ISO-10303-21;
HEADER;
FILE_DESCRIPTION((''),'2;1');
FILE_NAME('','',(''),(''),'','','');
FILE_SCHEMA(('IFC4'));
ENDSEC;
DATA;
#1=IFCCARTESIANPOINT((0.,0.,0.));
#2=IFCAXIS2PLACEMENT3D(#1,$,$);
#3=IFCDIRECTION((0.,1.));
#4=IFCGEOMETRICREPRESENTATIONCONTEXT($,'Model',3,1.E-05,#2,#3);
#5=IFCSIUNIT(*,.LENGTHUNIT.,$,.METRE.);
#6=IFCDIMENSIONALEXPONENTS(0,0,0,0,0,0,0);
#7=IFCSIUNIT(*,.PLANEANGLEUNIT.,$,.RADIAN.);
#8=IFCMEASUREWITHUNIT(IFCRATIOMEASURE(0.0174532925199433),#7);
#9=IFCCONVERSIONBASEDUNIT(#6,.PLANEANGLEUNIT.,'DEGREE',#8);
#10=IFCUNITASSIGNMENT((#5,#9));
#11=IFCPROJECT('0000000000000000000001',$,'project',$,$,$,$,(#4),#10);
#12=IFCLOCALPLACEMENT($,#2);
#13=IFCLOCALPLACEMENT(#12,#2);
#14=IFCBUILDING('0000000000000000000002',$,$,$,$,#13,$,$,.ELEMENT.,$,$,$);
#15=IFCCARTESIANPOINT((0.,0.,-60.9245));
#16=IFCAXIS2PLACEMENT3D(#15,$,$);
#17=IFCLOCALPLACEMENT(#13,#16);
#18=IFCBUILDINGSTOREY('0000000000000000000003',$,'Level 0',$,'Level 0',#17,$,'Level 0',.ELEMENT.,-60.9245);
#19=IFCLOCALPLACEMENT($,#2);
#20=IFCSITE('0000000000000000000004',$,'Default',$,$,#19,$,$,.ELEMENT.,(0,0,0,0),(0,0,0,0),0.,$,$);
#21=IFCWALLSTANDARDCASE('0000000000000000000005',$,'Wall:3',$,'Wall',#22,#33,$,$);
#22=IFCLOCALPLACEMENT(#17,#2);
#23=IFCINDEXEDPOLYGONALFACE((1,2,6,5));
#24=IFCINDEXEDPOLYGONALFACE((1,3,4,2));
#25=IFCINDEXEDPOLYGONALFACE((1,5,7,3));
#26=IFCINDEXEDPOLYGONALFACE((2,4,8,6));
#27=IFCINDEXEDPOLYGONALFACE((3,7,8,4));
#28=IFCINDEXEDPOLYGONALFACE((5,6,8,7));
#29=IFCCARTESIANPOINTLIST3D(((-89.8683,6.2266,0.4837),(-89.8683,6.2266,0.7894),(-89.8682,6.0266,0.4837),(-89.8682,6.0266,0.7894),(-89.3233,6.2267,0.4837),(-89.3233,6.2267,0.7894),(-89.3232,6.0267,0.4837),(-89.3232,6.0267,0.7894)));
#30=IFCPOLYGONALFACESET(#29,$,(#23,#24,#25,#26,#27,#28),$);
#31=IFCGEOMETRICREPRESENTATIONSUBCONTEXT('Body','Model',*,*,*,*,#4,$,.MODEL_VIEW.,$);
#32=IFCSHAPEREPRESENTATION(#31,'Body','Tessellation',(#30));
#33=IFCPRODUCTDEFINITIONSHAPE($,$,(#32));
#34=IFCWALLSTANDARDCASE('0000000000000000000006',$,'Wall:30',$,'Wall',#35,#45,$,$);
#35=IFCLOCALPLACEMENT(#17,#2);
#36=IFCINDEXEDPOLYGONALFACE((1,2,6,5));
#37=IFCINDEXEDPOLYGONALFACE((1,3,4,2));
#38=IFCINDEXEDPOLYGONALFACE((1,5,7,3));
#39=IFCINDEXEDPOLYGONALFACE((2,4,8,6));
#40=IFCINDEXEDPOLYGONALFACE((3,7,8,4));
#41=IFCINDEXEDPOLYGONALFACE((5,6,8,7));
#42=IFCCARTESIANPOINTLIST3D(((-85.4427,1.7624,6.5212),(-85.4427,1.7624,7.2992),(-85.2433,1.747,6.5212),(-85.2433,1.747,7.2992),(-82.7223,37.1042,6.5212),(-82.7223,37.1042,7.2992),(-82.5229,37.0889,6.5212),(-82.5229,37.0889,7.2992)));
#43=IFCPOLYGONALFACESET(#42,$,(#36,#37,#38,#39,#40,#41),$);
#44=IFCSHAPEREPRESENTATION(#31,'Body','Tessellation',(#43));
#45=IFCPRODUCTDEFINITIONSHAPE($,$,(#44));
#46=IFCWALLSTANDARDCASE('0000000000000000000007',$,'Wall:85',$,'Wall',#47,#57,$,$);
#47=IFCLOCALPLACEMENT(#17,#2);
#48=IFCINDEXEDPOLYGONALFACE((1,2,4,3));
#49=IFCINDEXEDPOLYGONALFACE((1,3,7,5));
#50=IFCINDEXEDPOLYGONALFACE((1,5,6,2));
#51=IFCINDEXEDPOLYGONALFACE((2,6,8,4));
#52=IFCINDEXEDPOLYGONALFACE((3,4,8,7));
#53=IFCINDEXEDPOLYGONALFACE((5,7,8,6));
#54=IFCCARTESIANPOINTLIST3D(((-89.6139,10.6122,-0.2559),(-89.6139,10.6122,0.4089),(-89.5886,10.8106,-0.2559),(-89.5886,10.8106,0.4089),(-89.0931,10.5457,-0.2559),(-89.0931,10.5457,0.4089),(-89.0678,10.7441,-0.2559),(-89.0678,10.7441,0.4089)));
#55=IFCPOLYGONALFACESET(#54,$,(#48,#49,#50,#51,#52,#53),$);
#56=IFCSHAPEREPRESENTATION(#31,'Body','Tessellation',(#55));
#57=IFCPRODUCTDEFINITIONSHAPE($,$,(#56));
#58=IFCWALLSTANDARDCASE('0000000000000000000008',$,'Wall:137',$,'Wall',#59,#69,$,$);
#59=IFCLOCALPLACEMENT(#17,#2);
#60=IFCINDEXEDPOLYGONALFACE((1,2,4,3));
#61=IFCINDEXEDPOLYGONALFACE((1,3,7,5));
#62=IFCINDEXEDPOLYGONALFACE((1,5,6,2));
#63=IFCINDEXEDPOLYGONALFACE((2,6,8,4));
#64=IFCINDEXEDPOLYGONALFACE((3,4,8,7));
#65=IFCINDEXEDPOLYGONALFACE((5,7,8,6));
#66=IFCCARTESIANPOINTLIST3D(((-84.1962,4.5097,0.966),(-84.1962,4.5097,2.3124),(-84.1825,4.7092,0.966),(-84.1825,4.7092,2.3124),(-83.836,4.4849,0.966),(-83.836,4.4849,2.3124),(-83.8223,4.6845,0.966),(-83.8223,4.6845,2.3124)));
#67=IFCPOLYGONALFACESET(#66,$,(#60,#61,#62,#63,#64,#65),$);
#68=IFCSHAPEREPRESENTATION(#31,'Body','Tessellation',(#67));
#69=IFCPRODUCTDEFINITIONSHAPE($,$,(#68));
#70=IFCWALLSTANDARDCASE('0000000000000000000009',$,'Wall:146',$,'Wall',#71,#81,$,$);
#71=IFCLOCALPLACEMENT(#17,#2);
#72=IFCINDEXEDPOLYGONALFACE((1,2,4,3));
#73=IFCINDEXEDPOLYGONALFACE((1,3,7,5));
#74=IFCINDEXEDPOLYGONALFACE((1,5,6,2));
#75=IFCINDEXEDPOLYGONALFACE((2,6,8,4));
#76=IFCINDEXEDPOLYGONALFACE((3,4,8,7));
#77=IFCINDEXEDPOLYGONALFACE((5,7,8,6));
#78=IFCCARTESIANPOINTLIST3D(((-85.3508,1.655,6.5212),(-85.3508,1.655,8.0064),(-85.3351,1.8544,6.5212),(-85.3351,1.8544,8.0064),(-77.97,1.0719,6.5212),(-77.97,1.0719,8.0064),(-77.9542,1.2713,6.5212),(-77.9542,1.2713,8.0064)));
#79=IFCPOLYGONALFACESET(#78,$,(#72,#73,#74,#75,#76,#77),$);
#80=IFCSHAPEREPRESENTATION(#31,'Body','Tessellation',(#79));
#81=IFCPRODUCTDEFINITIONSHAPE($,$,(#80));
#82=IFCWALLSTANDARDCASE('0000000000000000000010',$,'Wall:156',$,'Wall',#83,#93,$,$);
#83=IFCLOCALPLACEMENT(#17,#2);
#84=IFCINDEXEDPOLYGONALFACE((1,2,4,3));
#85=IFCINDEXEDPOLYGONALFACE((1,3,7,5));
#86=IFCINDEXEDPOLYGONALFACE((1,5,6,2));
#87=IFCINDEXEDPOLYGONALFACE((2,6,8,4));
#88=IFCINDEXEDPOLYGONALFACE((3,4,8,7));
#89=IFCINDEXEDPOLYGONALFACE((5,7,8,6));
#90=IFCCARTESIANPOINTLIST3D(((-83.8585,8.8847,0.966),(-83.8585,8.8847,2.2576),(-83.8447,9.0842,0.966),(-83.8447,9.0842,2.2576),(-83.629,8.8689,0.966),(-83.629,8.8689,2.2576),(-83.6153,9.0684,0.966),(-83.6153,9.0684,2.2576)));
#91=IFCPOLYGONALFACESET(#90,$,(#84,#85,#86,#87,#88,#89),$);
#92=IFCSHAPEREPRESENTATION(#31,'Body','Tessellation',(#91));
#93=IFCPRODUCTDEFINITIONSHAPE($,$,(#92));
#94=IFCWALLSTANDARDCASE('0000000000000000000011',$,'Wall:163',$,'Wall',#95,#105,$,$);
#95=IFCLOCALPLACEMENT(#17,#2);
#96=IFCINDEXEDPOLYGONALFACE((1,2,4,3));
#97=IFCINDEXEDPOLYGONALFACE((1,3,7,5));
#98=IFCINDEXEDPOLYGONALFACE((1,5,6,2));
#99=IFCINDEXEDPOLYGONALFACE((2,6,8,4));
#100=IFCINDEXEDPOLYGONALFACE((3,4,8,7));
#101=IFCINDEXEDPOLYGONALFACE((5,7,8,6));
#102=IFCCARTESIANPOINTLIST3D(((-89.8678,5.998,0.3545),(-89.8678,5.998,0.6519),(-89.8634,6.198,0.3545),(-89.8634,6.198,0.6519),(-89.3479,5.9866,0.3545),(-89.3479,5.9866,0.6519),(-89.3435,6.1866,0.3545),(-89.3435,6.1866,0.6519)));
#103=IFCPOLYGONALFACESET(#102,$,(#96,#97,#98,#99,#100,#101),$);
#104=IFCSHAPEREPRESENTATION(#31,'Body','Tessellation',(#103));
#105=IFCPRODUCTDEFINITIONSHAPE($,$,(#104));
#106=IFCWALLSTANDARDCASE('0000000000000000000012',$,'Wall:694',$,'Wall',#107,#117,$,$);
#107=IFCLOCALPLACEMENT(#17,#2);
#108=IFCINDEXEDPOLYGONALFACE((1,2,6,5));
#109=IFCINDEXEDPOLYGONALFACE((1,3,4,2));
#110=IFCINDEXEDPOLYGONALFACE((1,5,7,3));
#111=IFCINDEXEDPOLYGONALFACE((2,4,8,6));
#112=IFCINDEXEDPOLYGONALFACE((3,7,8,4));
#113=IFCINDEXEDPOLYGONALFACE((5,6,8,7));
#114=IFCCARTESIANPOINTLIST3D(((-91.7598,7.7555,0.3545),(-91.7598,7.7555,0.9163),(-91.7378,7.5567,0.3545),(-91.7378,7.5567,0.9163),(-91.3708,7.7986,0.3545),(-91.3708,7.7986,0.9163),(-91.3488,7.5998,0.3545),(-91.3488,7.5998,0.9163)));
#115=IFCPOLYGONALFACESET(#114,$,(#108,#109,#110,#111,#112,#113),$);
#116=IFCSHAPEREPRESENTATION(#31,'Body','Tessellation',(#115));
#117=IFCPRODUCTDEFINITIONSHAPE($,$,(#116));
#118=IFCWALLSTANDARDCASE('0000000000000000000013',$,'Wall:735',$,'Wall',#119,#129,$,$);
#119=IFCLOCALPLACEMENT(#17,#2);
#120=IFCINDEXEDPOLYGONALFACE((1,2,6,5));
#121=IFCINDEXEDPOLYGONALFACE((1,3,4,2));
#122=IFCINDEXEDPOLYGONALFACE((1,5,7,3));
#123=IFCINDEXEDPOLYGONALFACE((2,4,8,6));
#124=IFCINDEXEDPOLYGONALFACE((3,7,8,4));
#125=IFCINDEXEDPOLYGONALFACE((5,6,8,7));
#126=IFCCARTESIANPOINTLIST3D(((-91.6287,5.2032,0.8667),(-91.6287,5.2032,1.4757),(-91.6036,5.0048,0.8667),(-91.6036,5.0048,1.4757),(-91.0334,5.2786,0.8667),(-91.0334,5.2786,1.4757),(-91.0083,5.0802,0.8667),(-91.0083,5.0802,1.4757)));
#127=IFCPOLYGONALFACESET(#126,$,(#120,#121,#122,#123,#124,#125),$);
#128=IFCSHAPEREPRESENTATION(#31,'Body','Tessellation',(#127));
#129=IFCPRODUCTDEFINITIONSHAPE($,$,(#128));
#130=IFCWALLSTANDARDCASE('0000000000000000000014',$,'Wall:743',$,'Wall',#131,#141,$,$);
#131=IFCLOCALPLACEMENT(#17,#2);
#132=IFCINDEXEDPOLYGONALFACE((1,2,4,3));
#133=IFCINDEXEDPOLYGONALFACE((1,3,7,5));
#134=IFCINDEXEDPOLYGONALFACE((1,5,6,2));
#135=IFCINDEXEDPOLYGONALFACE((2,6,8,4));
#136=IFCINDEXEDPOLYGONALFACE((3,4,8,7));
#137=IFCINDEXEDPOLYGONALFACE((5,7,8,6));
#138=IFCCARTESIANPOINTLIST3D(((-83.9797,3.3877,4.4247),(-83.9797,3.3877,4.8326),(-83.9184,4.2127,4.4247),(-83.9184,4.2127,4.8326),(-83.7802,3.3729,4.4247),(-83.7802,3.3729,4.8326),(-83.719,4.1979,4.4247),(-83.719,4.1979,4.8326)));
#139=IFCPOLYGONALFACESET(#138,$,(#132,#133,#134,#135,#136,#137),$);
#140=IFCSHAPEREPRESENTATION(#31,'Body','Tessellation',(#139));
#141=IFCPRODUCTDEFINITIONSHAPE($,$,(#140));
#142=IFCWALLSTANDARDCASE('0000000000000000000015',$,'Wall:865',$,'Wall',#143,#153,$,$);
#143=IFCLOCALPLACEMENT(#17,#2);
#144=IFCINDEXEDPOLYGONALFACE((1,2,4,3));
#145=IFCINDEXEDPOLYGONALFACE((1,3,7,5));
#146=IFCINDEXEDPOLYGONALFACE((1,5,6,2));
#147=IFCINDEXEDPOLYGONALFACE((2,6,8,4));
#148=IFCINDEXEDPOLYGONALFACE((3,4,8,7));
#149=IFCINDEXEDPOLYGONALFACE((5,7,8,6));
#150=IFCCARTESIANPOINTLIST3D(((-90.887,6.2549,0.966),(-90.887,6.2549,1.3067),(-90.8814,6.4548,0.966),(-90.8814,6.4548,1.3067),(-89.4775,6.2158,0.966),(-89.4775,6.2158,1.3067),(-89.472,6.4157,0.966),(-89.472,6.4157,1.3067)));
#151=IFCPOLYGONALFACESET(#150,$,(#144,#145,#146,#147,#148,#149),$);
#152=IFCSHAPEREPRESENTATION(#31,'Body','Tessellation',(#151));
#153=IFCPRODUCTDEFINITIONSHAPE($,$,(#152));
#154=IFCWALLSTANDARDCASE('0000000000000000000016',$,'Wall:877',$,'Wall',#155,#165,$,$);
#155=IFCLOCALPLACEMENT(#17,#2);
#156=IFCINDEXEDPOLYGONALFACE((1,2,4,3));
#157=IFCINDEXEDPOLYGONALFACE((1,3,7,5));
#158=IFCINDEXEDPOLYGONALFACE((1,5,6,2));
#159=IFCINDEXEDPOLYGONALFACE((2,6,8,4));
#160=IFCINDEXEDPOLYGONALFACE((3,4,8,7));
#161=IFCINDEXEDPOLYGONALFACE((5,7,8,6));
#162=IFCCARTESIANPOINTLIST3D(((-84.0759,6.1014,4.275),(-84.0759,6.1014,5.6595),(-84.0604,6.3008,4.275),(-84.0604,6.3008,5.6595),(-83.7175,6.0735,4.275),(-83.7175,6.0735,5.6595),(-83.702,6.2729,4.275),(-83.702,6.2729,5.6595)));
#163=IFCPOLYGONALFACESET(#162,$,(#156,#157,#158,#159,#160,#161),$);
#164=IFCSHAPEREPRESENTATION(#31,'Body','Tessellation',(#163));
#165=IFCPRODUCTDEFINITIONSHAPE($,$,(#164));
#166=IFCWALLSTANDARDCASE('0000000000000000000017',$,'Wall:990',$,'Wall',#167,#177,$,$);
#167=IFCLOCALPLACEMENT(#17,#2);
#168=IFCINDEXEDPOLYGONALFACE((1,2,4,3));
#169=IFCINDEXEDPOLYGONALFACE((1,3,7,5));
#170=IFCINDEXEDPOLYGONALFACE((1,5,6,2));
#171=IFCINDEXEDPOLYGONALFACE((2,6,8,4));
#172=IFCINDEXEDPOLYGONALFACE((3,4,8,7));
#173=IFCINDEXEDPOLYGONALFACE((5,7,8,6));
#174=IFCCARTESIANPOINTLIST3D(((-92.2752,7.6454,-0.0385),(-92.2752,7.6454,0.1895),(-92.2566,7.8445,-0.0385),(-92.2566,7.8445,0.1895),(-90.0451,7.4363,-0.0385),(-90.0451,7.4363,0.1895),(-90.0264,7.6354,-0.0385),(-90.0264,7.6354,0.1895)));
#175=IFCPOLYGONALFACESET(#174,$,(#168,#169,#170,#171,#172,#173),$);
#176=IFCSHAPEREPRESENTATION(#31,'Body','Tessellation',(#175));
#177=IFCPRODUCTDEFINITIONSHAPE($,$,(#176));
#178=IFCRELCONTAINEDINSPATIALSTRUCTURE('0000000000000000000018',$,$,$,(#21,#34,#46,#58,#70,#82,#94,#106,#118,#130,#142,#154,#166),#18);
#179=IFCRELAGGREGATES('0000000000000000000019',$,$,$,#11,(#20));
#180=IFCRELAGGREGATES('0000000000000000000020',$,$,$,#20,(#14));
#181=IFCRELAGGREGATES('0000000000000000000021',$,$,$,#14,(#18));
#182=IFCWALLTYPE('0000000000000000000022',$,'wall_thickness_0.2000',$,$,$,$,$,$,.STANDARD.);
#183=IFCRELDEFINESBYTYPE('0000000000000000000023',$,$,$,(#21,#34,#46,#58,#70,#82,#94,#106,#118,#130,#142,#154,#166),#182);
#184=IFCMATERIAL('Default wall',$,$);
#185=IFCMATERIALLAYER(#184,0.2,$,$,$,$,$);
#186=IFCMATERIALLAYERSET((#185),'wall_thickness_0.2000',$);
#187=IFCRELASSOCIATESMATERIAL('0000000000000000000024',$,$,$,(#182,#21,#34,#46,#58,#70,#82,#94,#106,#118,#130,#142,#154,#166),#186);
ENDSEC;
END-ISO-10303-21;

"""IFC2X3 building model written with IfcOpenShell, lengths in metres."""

from ifc_helpers import new_model, entity, si_unit, converted_unit, direction, frame, origin, place, context, subcontext, project, spatial, polyline, outline, extrude, material, layer, layer_set, layer_usage, type_object, element, save


model = new_model("IFC2X3")

# Units and contexts
model_context = context("Model", 3, precision=1e-05, world=origin(), true_north=direction((0.0, 1.0)))
body_context = subcontext(model_context, "Body", "Model", "MODEL_VIEW")
ifc_project = project(units=[si_unit("LENGTHUNIT", "METRE"), converted_unit("PLANEANGLEUNIT", "DEGREE", entity("IfcRatioMeasure", 0.0174532925199433), si_unit("PLANEANGLEUNIT", "RADIAN"), dimensions=[0, 0, 0, 0, 0, 0, 0])], contexts=[model_context])

# Site, building, storey
site_placement = place(None, origin())
site = spatial("IfcSite", under=ifc_project, at=site_placement, Name="Default", CompositionType="ELEMENT", RefLatitude=(0, 0, 0, 0), RefLongitude=(0, 0, 0, 0), RefElevation=0.0)
placement_1 = place(None, origin())
building_placement = place(placement_1, origin())
building = spatial("IfcBuilding", under=site, at=building_placement, CompositionType="ELEMENT")
storey_placement = place(building_placement, frame((0.0, 0.0, -60.9245)))
storey = spatial("IfcBuildingStorey", under=building, at=storey_placement, Name="Level 0", ObjectType="Level 0", LongName="Level 0", CompositionType="ELEMENT", Elevation=-60.9245)

# Walls
ifc_material = material(Name="Default wall")
ifc_layer = layer(ifc_material, 0.2)
ifc_layer_set = layer_set([ifc_layer], Name="wall_thickness_0.2000")
ifc_layer_usage = layer_usage(ifc_layer_set, "AXIS2", "POSITIVE", -0.1)
wall_type = type_object("IfcWallType", Name="wall_thickness_0.2000", PredefinedType="STANDARD", material=ifc_layer_set)
placement_2 = place(building_placement, frame((0.0, 0.0, -60.4408)))
wall_1_placement = place(placement_2, frame((-89.8683, 6.1266, 0.0), z_axis=(0.0, 0.0, 1.0), x_axis=(1.0, 0.000196, 0.0)))
element("IfcWallStandardCase", 1, at=wall_1_placement, inside=storey, type_object=wall_type, material=ifc_layer_usage, Name="Wall:3", ObjectType="Wall", context=body_context, shape_type="SweptSolid", body=[
    extrude(outline(polyline([(0.545, -0.1), (0.545, 0.1), (0.0, 0.1), (0.0, -0.1), (0.545, -0.1)])), origin(), (0.0, 0.0, 1.0), 0.3057),
])
placement_3 = place(building_placement, frame((0.0, 0.0, -54.4033)))
wall_2_placement = place(placement_3, frame((-85.343, 1.7547, 0.0), z_axis=(0.0, 0.0, 1.0), x_axis=(0.076745, 0.997051, 0.0)))
element("IfcWallStandardCase", 2, at=wall_2_placement, inside=storey, type_object=wall_type, material=ifc_layer_usage, Name="Wall:30", ObjectType="Wall", context=body_context, shape_type="SweptSolid", body=[
    extrude(outline(polyline([(35.4464, -0.1), (35.4464, 0.1), (0.0, 0.1), (0.0, -0.1), (35.4464, -0.1)])), origin(), (0.0, 0.0, 1.0), 0.778),
])
placement_4 = place(building_placement, frame((0.0, 0.0, -61.1804)))
wall_3_placement = place(placement_4, frame((-89.0804, 10.6449, 0.0), z_axis=(0.0, 0.0, 1.0), x_axis=(-0.991957, 0.126572, 0.0)))
element("IfcWallStandardCase", 3, at=wall_3_placement, inside=storey, type_object=wall_type, material=ifc_layer_usage, Name="Wall:85", ObjectType="Wall", context=body_context, shape_type="SweptSolid", body=[
    extrude(outline(polyline([(0.525, -0.1), (0.525, 0.1), (0.0, 0.1), (0.0, -0.1), (0.525, -0.1)])), origin(), (0.0, 0.0, 1.0), 0.6648),
])
placement_5 = place(building_placement, frame((0.0, 0.0, -59.9585)))
wall_4_placement = place(placement_5, frame((-83.8291, 4.5847, 0.0), z_axis=(0.0, 0.0, 1.0), x_axis=(-0.99765, 0.068523, 0.0)))
element("IfcWallStandardCase", 4, at=wall_4_placement, inside=storey, type_object=wall_type, material=ifc_layer_usage, Name="Wall:137", ObjectType="Wall", context=body_context, shape_type="SweptSolid", body=[
    extrude(outline(polyline([(0.3611, -0.1), (0.3611, 0.1), (0.0, 0.1), (0.0, -0.1), (0.3611, -0.1)])), origin(), (0.0, 0.0, 1.0), 1.3464),
])
placement_6 = place(building_placement, frame((0.0, 0.0, -54.4033)))
wall_5_placement = place(placement_6, frame((-85.343, 1.7547, 0.0), z_axis=(0.0, 0.0, 1.0), x_axis=(0.996894, -0.078756, 0.0)))
element("IfcWallStandardCase", 5, at=wall_5_placement, inside=storey, type_object=wall_type, material=ifc_layer_usage, Name="Wall:146", ObjectType="Wall", context=body_context, shape_type="SweptSolid", body=[
    extrude(outline(polyline([(7.4039, -0.1), (7.4039, 0.1), (0.0, 0.1), (0.0, -0.1), (7.4039, -0.1)])), origin(), (0.0, 0.0, 1.0), 1.4852),
])
placement_7 = place(building_placement, frame((0.0, 0.0, -59.9585)))
wall_6_placement = place(placement_7, frame((-83.6221, 8.9687, 0.0), z_axis=(0.0, 0.0, 1.0), x_axis=(-0.997646, 0.068568, 0.0)))
element("IfcWallStandardCase", 6, at=wall_6_placement, inside=storey, type_object=wall_type, material=ifc_layer_usage, Name="Wall:156", ObjectType="Wall", context=body_context, shape_type="SweptSolid", body=[
    extrude(outline(polyline([(0.23, -0.1), (0.23, 0.1), (0.0, 0.1), (0.0, -0.1), (0.23, -0.1)])), origin(), (0.0, 0.0, 1.0), 1.2916),
])
placement_8 = place(building_placement, frame((0.0, 0.0, -60.57)))
wall_7_placement = place(placement_8, frame((-89.8656, 6.098, 0.0), z_axis=(0.0, 0.0, 1.0), x_axis=(0.999761, -0.02187, 0.0)))
element("IfcWallStandardCase", 7, at=wall_7_placement, inside=storey, type_object=wall_type, material=ifc_layer_usage, Name="Wall:163", ObjectType="Wall", context=body_context, shape_type="SweptSolid", body=[
    extrude(outline(polyline([(0.52, -0.1), (0.52, 0.1), (0.0, 0.1), (0.0, -0.1), (0.52, -0.1)])), origin(), (0.0, 0.0, 1.0), 0.2973),
])
placement_9 = place(building_placement, frame((0.0, 0.0, -60.57)))
wall_8_placement = place(placement_9, frame((-91.7488, 7.6561, 0.0), z_axis=(0.0, 0.0, 1.0), x_axis=(0.993922, 0.110088, 0.0)))
element("IfcWallStandardCase", 8, at=wall_8_placement, inside=storey, type_object=wall_type, material=ifc_layer_usage, Name="Wall:694", ObjectType="Wall", context=body_context, shape_type="SweptSolid", body=[
    extrude(outline(polyline([(0.3914, -0.1), (0.3914, 0.1), (0.0, 0.1), (0.0, -0.1), (0.3914, -0.1)])), origin(), (0.0, 0.0, 1.0), 0.5618),
])
placement_10 = place(building_placement, frame((0.0, 0.0, -60.0578)))
wall_9_placement = place(placement_10, frame((-91.0209, 5.1794, 0.0), z_axis=(0.0, 0.0, 1.0), x_axis=(-0.992073, -0.125664, 0.0)))
element("IfcWallStandardCase", 9, at=wall_9_placement, inside=storey, type_object=wall_type, material=ifc_layer_usage, Name="Wall:735", ObjectType="Wall", context=body_context, shape_type="SweptSolid", body=[
    extrude(outline(polyline([(0.6001, -0.1), (0.6001, 0.1), (0.0, 0.1), (0.0, -0.1), (0.6001, -0.1)])), origin(), (0.0, 0.0, 1.0), 0.609),
])
placement_11 = place(building_placement, frame((0.0, 0.0, -56.4998)))
wall_10_placement = place(placement_11, frame((-83.8187, 4.2053, 0.0), z_axis=(0.0, 0.0, 1.0), x_axis=(-0.074081, -0.997252, 0.0)))
element("IfcWallStandardCase", 10, at=wall_10_placement, inside=storey, type_object=wall_type, material=ifc_layer_usage, Name="Wall:743", ObjectType="Wall", context=body_context, shape_type="SweptSolid", body=[
    extrude(outline(polyline([(0.8273, -0.1), (0.8273, 0.1), (0.0, 0.1), (0.0, -0.1), (0.8273, -0.1)])), origin(), (0.0, 0.0, 1.0), 0.4079),
])
placement_12 = place(building_placement, frame((0.0, 0.0, -59.9585)))
wall_11_placement = place(placement_12, frame((-90.8842, 6.3548, 0.0), z_axis=(0.0, 0.0, 1.0), x_axis=(0.999616, -0.027694, 0.0)))
element("IfcWallStandardCase", 11, at=wall_11_placement, inside=storey, type_object=wall_type, material=ifc_layer_usage, Name="Wall:865", ObjectType="Wall", context=body_context, shape_type="SweptSolid", body=[
    extrude(outline(polyline([(1.41, -0.1), (1.41, 0.1), (0.0, 0.1), (0.0, -0.1), (1.41, -0.1)])), origin(), (0.0, 0.0, 1.0), 0.3407),
])
placement_13 = place(building_placement, frame((0.0, 0.0, -56.6495)))
wall_12_placement = place(placement_13, frame((-83.7097, 6.1732, 0.0), z_axis=(0.0, 0.0, 1.0), x_axis=(-0.996986, 0.077578, 0.0)))
element("IfcWallStandardCase", 12, at=wall_12_placement, inside=storey, type_object=wall_type, material=ifc_layer_usage, Name="Wall:877", ObjectType="Wall", context=body_context, shape_type="SweptSolid", body=[
    extrude(outline(polyline([(0.3595, -0.1), (0.3595, 0.1), (0.0, 0.1), (0.0, -0.1), (0.3595, -0.1)])), origin(), (0.0, 0.0, 1.0), 1.3845),
])
placement_14 = place(building_placement, frame((0.0, 0.0, -60.963)))
wall_13_placement = place(placement_14, frame((-92.2659, 7.7449, 0.0), z_axis=(0.0, 0.0, 1.0), x_axis=(0.995635, -0.093334, 0.0)))
element("IfcWallStandardCase", 13, at=wall_13_placement, inside=storey, type_object=wall_type, material=ifc_layer_usage, Name="Wall:990", ObjectType="Wall", context=body_context, shape_type="SweptSolid", body=[
    extrude(outline(polyline([(2.2399, -0.1), (2.2399, 0.1), (0.0, 0.1), (0.0, -0.1), (2.2399, -0.1)])), origin(), (0.0, 0.0, 1.0), 0.2281),
])

save(model, "model.ifc")
